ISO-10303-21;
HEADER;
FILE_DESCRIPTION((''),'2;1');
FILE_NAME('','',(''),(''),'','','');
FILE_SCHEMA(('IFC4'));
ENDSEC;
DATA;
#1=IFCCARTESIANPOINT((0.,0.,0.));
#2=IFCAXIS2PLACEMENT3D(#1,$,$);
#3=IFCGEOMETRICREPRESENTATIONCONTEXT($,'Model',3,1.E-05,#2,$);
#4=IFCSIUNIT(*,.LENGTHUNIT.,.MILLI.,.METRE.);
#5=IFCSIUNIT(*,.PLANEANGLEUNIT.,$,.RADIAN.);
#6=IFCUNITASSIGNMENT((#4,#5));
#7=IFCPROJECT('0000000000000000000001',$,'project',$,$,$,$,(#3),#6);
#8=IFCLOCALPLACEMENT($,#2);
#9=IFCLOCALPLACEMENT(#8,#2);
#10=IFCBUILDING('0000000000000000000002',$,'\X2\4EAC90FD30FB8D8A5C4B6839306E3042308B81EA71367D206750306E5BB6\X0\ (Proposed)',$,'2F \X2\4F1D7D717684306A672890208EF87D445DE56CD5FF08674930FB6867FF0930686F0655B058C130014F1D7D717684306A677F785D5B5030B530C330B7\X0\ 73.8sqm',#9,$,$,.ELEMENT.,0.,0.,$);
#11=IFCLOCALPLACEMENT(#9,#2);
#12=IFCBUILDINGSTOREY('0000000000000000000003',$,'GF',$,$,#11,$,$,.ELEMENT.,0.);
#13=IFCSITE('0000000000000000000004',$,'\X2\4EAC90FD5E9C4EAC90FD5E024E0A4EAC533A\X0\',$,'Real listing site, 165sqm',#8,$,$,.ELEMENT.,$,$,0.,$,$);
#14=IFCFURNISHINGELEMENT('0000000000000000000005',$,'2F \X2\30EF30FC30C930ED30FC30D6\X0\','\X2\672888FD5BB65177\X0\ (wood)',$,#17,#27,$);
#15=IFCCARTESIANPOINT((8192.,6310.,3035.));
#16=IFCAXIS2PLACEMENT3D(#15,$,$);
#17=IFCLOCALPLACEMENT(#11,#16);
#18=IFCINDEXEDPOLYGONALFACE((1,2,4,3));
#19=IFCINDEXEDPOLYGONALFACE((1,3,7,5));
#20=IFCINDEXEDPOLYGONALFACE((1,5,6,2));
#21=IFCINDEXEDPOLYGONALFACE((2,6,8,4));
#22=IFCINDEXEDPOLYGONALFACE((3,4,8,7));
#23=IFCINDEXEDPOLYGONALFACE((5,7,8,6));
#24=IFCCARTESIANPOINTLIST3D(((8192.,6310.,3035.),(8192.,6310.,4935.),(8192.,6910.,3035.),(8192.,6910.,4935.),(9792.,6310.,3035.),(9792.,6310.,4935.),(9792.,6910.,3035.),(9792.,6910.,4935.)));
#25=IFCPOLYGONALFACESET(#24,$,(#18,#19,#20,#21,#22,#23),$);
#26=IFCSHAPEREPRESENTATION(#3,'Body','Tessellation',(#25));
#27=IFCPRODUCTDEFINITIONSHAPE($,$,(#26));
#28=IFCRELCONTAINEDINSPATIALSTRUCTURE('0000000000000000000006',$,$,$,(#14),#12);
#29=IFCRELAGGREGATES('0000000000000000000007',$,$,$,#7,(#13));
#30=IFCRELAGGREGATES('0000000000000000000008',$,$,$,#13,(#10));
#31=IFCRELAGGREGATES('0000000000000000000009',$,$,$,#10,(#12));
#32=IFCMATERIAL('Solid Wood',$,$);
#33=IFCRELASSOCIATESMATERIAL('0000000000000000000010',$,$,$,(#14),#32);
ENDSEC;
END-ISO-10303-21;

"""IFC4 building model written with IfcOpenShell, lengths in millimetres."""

from ifc_helpers import new_model, si_unit, frame, frame_2d, origin, place, context, project, spatial, rectangle, extrude, material, element, save


model = new_model("IFC4")

# Units and contexts
model_context = context("Model", 3, precision=1e-05, world=origin())
ifc_project = project(units=[si_unit("LENGTHUNIT", "METRE", prefix="MILLI"), si_unit("PLANEANGLEUNIT", "RADIAN")], contexts=[model_context])

# Site, building, storey
site_placement = place(None, origin())
site = spatial("IfcSite", under=ifc_project, at=site_placement, Name="京都府京都市上京区", ObjectType="Real listing site, 165sqm", CompositionType="ELEMENT", RefElevation=0.0)
building_placement = place(site_placement, origin())
building = spatial("IfcBuilding", under=site, at=building_placement, Name="京都・越屋根のある自然素材の家 (Proposed)", ObjectType="2F 伝統的な木造軸組工法（杉・桧）と漆喰壁、伝統的な板硝子サッシ 73.8sqm", CompositionType="ELEMENT", ElevationOfRefHeight=0.0, ElevationOfTerrain=0.0)
storey_placement = place(building_placement, origin())
storey = spatial("IfcBuildingStorey", under=building, at=storey_placement, Name="GF", CompositionType="ELEMENT", Elevation=0.0)

# Shared definitions
ifc_material_1 = material(Name="Solid Wood")

# Furnishing element
furnishing_1_placement = place(storey_placement, frame((8192.0, 6310.0, 3035.0)))
element("IfcFurnishingElement", 1, at=furnishing_1_placement, inside=storey, material=ifc_material_1, Name="2F ワードローブ", Description="木製家具 (wood)", context=model_context, shape_type="SweptSolid", body=[
    extrude(rectangle(XDim=1600.0, YDim=600.0, at=frame_2d((800.0, 300.0))), frame((8192.0, 6310.0, 3035.0)), (0.0, 0.0, 1.0), 1900.0),
])

save(model, "model.ifc")
